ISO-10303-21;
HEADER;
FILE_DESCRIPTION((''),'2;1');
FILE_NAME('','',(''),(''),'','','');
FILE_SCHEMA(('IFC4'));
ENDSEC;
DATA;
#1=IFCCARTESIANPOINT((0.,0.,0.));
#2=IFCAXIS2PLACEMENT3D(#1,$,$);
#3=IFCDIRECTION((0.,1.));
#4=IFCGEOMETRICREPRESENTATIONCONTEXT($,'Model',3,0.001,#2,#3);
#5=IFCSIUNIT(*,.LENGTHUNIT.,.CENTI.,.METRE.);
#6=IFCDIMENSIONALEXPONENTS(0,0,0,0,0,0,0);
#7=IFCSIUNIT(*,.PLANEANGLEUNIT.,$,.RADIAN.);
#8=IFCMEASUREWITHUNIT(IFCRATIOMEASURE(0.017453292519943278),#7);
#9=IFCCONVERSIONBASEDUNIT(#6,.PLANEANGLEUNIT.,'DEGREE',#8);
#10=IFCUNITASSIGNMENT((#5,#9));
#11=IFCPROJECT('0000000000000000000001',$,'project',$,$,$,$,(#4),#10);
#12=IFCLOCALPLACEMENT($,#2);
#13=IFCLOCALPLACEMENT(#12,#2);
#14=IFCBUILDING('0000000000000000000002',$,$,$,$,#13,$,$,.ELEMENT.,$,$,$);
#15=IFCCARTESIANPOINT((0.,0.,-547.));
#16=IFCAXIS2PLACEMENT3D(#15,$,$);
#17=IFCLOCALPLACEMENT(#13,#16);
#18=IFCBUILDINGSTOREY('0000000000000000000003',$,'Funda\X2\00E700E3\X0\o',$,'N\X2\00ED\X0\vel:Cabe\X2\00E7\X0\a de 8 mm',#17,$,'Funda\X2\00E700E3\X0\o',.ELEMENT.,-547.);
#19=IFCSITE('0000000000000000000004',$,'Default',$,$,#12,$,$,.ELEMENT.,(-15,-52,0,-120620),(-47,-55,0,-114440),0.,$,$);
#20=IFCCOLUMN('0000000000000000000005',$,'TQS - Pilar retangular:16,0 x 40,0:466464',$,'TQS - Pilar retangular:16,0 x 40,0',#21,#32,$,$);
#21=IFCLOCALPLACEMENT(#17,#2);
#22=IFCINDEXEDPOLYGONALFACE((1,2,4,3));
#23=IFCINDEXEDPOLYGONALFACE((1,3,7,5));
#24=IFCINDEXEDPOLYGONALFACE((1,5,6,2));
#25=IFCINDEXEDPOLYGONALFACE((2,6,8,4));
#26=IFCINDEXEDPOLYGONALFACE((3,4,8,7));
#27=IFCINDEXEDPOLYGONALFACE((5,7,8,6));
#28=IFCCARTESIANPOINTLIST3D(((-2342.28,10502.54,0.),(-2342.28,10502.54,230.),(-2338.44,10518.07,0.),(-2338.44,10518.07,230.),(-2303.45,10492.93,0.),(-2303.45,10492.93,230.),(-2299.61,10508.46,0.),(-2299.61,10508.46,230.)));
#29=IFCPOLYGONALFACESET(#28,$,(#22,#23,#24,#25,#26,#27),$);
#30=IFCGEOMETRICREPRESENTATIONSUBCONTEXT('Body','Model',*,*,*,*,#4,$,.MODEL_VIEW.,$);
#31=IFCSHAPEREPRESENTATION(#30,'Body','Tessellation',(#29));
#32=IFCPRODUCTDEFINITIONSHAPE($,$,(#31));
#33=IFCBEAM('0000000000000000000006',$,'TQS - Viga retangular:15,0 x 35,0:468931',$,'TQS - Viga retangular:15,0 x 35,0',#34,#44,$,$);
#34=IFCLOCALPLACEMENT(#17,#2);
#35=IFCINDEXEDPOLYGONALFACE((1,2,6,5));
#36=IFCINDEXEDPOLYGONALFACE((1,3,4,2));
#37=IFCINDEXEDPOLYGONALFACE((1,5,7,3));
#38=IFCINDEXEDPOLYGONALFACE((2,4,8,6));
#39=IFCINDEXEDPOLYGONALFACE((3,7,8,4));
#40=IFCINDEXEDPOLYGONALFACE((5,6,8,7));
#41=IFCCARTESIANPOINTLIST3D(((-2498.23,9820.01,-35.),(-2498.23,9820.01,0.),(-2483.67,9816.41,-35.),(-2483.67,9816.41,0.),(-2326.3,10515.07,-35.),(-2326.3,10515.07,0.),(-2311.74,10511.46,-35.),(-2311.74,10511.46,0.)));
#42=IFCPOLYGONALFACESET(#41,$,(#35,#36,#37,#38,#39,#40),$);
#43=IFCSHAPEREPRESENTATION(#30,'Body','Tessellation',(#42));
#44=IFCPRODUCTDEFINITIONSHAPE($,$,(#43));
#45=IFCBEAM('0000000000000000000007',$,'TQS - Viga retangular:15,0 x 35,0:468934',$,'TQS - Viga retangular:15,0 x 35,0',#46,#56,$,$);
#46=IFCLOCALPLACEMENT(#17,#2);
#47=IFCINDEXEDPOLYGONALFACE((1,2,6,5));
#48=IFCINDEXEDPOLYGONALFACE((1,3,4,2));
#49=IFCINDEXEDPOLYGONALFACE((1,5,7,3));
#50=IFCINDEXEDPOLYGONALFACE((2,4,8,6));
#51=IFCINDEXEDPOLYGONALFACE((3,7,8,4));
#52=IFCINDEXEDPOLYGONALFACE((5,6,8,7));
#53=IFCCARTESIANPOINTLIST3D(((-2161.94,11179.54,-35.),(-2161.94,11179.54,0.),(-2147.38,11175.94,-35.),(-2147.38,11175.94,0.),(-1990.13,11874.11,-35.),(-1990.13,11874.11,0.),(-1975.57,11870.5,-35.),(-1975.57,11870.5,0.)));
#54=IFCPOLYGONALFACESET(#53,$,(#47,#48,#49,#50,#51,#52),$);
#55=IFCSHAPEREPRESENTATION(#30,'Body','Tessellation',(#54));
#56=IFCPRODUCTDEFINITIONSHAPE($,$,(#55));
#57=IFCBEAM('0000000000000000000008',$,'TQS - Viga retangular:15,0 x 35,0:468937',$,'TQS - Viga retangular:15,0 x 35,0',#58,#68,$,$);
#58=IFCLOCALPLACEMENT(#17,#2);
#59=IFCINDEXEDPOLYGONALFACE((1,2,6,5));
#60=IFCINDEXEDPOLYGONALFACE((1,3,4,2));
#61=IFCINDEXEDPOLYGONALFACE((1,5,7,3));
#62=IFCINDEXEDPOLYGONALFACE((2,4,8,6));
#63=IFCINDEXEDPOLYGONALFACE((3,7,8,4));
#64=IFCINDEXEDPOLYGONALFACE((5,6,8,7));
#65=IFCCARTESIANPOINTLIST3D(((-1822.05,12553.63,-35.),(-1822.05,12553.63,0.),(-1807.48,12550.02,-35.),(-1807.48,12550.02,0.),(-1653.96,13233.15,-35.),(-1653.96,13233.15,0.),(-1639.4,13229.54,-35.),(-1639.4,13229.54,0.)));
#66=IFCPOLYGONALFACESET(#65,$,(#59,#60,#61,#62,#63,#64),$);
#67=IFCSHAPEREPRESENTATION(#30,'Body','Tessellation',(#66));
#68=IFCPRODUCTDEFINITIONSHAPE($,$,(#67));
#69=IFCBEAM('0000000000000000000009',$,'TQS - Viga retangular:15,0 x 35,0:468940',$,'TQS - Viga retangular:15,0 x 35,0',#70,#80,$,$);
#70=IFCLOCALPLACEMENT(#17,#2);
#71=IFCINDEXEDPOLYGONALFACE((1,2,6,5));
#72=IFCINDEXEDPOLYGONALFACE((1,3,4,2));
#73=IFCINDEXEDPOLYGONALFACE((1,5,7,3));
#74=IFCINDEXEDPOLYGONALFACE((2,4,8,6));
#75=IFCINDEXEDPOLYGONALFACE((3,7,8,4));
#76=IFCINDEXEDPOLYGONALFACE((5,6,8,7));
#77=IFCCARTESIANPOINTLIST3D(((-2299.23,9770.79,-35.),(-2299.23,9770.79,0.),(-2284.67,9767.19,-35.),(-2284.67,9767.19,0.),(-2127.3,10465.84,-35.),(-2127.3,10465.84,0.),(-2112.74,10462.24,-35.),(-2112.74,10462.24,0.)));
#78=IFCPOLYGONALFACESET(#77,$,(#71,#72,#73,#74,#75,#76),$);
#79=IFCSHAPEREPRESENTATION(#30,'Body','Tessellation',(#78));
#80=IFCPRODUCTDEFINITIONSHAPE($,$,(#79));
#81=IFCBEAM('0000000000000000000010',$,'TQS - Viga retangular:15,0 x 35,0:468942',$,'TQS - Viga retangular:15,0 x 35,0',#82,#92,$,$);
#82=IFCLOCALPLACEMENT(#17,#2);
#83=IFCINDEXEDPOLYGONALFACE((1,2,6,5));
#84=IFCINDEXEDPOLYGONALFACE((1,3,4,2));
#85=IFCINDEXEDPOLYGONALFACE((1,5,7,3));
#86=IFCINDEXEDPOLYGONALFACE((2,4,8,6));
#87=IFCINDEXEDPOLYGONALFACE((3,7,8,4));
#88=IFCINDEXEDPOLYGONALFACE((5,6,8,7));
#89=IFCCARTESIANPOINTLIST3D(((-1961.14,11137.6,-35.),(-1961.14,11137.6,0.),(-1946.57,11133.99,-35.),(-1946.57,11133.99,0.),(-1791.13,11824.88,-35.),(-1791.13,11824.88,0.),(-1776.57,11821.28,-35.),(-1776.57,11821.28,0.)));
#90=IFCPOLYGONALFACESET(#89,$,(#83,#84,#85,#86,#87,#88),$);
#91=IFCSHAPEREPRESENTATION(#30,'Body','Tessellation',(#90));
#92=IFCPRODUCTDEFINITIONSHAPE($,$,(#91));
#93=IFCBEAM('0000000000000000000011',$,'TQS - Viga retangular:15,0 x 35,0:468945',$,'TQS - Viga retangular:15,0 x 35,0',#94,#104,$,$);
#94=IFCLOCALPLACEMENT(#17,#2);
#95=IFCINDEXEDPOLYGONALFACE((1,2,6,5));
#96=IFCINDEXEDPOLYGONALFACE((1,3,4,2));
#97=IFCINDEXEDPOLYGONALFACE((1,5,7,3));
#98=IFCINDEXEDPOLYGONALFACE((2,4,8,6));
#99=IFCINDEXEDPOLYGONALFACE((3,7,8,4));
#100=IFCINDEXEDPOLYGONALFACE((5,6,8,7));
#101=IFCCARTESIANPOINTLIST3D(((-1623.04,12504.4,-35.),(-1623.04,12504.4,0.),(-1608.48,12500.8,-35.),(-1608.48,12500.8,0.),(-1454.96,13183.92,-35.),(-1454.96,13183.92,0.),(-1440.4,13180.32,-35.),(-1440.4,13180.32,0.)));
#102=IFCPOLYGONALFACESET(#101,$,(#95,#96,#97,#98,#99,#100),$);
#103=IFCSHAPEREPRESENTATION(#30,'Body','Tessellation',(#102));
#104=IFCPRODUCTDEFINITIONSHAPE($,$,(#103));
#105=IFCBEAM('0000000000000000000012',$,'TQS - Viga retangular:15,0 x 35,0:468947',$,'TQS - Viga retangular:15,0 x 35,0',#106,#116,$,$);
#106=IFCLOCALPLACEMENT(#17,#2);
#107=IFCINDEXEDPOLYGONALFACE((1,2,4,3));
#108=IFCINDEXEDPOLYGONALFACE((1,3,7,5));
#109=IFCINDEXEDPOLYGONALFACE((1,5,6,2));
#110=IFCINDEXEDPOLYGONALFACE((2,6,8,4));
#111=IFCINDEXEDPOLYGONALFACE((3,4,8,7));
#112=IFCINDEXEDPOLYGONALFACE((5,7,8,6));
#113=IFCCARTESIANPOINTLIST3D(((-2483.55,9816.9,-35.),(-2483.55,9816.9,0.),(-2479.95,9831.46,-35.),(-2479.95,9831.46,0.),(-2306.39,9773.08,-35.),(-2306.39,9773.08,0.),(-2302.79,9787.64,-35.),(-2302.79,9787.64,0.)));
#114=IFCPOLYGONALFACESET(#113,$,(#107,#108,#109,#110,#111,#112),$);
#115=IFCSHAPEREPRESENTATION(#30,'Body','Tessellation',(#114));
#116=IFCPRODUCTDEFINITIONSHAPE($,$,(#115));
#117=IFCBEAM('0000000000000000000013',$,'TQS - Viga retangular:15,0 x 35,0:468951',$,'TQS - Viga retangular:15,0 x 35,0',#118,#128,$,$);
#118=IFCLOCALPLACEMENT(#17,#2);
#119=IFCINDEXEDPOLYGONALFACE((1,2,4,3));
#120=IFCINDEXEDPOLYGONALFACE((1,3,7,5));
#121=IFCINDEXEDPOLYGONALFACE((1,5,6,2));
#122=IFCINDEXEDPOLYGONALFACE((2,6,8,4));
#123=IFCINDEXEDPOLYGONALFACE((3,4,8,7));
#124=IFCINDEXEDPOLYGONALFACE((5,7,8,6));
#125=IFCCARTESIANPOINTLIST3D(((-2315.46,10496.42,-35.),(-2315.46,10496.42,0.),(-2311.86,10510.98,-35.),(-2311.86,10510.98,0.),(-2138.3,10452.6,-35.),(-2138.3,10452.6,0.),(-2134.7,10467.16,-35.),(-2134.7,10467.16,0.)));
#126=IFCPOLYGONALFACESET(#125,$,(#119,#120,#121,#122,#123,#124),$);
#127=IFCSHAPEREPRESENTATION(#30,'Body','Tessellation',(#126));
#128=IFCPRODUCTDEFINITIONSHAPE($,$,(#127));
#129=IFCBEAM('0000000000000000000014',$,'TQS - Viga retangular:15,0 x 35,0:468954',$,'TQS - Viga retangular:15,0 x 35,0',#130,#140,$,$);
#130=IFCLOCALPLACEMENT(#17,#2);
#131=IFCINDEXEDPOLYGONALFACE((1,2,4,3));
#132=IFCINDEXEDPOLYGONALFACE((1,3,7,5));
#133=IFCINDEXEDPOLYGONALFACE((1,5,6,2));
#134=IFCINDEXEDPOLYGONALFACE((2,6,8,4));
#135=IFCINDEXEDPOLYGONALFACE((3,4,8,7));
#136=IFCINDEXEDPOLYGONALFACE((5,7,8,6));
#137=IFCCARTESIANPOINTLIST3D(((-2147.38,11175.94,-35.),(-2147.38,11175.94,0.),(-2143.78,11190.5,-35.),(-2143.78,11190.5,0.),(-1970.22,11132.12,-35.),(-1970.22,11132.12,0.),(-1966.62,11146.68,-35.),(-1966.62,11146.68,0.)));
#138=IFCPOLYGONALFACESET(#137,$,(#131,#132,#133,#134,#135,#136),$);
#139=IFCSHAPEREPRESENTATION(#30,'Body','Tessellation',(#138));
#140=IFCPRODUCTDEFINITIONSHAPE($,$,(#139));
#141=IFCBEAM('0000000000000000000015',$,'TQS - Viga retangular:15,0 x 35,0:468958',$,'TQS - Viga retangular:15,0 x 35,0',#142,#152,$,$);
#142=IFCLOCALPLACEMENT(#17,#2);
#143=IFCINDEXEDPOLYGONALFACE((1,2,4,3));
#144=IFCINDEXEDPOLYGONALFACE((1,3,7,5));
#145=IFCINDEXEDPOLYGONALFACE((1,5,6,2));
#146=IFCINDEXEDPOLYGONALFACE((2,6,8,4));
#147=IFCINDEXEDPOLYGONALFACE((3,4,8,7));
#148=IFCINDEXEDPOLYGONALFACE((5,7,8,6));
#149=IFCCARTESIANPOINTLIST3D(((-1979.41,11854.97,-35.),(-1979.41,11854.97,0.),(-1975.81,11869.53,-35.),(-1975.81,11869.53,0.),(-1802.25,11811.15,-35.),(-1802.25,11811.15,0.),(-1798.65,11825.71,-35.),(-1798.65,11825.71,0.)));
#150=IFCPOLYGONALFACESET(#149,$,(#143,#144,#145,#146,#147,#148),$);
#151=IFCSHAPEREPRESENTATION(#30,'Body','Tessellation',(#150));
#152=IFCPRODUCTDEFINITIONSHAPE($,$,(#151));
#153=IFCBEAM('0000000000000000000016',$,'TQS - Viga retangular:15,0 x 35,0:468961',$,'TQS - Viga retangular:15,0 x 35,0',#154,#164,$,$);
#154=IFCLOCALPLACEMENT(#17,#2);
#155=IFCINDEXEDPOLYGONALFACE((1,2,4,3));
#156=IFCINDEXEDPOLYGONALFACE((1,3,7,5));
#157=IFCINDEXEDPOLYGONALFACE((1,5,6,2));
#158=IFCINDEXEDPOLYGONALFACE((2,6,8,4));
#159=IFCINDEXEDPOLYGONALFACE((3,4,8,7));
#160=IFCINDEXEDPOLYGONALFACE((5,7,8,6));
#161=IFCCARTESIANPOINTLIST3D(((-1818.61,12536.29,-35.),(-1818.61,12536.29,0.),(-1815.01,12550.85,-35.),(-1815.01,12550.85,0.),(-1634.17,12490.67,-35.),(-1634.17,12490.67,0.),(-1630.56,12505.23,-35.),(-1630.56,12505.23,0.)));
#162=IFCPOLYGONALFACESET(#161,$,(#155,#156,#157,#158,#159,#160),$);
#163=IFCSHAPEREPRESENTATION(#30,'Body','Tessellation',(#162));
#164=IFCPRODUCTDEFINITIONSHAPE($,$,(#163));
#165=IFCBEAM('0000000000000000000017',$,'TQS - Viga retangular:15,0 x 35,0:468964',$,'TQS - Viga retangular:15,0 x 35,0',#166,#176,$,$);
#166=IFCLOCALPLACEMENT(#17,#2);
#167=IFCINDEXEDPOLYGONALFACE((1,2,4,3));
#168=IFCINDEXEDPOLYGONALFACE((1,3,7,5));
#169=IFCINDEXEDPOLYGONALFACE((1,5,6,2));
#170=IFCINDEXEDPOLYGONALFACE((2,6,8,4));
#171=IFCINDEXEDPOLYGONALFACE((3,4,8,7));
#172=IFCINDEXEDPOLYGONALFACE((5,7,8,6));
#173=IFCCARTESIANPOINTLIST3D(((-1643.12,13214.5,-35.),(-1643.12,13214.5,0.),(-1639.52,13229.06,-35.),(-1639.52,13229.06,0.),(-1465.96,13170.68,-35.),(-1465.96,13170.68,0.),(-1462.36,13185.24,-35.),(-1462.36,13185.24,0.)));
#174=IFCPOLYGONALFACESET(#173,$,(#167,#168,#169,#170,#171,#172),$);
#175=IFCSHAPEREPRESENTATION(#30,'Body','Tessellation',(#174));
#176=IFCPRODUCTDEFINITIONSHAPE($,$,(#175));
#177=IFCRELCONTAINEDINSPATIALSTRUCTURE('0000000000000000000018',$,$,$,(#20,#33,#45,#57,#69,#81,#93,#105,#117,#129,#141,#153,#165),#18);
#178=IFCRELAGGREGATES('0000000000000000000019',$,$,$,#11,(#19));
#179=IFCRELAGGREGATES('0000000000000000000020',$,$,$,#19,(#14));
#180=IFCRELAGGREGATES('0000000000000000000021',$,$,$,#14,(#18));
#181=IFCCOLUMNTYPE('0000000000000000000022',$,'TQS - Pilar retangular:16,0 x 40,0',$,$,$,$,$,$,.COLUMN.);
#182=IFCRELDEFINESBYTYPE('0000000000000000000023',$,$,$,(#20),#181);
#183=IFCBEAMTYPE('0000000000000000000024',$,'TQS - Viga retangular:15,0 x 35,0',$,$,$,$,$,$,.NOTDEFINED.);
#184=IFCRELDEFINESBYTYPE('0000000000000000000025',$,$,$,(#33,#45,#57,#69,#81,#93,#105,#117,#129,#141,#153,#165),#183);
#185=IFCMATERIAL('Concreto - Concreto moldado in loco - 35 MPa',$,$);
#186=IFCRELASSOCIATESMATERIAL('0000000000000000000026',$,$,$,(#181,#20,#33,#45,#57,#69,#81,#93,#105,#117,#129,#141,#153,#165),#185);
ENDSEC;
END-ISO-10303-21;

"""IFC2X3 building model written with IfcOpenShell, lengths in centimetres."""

from ifc_helpers import new_model, entity, si_unit, converted_unit, direction, frame, frame_2d, origin, origin_2d_with_axis, place, context, subcontext, project, spatial, rectangle, extrude, source, transform, mapped, material, type_object, type_shapes, element, save


model = new_model("IFC2X3")

# Units and contexts
model_context = context("Model", 3, precision=0.001, world=origin(), true_north=direction((0.0, 1.0)))
body_context = subcontext(model_context, "Body", "Model", "MODEL_VIEW")
ifc_project = project(units=[si_unit("LENGTHUNIT", "METRE", prefix="CENTI"), converted_unit("PLANEANGLEUNIT", "DEGREE", entity("IfcRatioMeasure", 0.017453292519943278), si_unit("PLANEANGLEUNIT", "RADIAN"), dimensions=[0, 0, 0, 0, 0, 0, 0])], contexts=[model_context])

# Site, building, storey
site_placement = place(None, origin())
site = spatial("IfcSite", under=ifc_project, at=site_placement, Name="Default", CompositionType="ELEMENT", RefLatitude=(-15, -52, 0, -120620), RefLongitude=(-47, -55, 0, -114440), RefElevation=0.0)
building_placement = place(site_placement, origin())
building = spatial("IfcBuilding", under=site, at=building_placement, CompositionType="ELEMENT")
storey_placement = place(building_placement, frame((0.0, 0.0, -547.0)))
storey = spatial("IfcBuildingStorey", under=building, at=storey_placement, Name="Fundação", ObjectType="Nível:Cabeça de 8 mm", LongName="Fundação", CompositionType="ELEMENT", Elevation=-547.0)

# Column
ifc_material_1 = material(Name="Concreto - Concreto moldado in loco - 35 MPa")
column_type_1 = type_object("IfcColumnType", Name="TQS - Pilar retangular:16,0 x 40,0", PredefinedType="COLUMN", material=ifc_material_1)
shared_shape_1 = source(origin(), body_context, "Body", "SweptSolid", [
    extrude(rectangle(XDim=40.0, YDim=16.0, at=origin_2d_with_axis()), frame((-2320.94, 10505.5, -547.0), z_axis=(0.0, 0.0, 1.0), x_axis=(-0.970743, 0.240122, 0.0)), (0.0, 0.0, 1.0), 230.0),
])
type_shapes(column_type_1, [shared_shape_1])
column_1_placement = place(storey_placement, frame((0.0, 0.0, 547.0)))
element("IfcColumn", 1, at=column_1_placement, inside=storey, type_object=column_type_1, material=ifc_material_1, Name="TQS - Pilar retangular:16,0 x 40,0:466464", ObjectType="TQS - Pilar retangular:16,0 x 40,0", context=body_context, shape_type="MappedRepresentation", body=[
    mapped(shared_shape_1, transform((0.0, 0.0, 0.0), scale=1.0)),
])

# Beams
beam_type = type_object("IfcBeamType", Name="TQS - Viga retangular:15,0 x 35,0", PredefinedType="NOTDEFINED")
beam_1_placement = place(storey_placement, frame((-2490.95, 9818.21, 0.0), z_axis=(0.0, 0.0, 1.0), x_axis=(0.240122, 0.970743, 0.0)))
element("IfcBeam", 2, at=beam_1_placement, inside=storey, type_object=beam_type, material=ifc_material_1, Name="TQS - Viga retangular:15,0 x 35,0:468931", ObjectType="TQS - Viga retangular:15,0 x 35,0", context=body_context, shape_type="SweptSolid", body=[
    extrude(rectangle(XDim=35.0, YDim=15.0, at=frame_2d((0.0, 0.0), x_axis=(1.0, 0.0))), frame((0.0, 0.0, -17.5), z_axis=(1.0, 0.0, 0.0), x_axis=(0.0, 0.0, -1.0)), (0.0, 0.0, 1.0), 716.0),
])
beam_2_placement = place(storey_placement, frame((-2152.86, 11185.02, 0.0), z_axis=(0.0, 0.0, 1.0), x_axis=(0.240122, 0.970743, 0.0)))
element("IfcBeam", 3, at=beam_2_placement, inside=storey, type_object=beam_type, material=ifc_material_1, Name="TQS - Viga retangular:15,0 x 35,0:468934", ObjectType="TQS - Viga retangular:15,0 x 35,0", context=body_context, shape_type="SweptSolid", body=[
    extrude(rectangle(XDim=35.0, YDim=15.0, at=frame_2d((0.0, 0.0), x_axis=(1.0, 0.0))), frame((-7.5, 0.0, -17.5), z_axis=(1.0, 0.0, 0.0), x_axis=(0.0, 0.0, -1.0)), (0.0, 0.0, 1.0), 715.5),
])
beam_3_placement = place(storey_placement, frame((-1814.77, 12551.83, 0.0), z_axis=(0.0, 0.0, 1.0), x_axis=(0.240122, 0.970743, 0.0)))
element("IfcBeam", 4, at=beam_3_placement, inside=storey, type_object=beam_type, material=ifc_material_1, Name="TQS - Viga retangular:15,0 x 35,0:468937", ObjectType="TQS - Viga retangular:15,0 x 35,0", context=body_context, shape_type="SweptSolid", body=[
    extrude(rectangle(XDim=35.0, YDim=15.0, at=frame_2d((0.0, 0.0), x_axis=(1.0, 0.0))), frame((0.0, 0.0, -17.5), z_axis=(1.0, 0.0, 0.0), x_axis=(0.0, 0.0, -1.0)), (0.0, 0.0, 1.0), 700.0),
])
beam_4_placement = place(storey_placement, frame((-2291.95, 9768.99, 0.0), z_axis=(0.0, 0.0, 1.0), x_axis=(0.240122, 0.970743, 0.0)))
element("IfcBeam", 5, at=beam_4_placement, inside=storey, type_object=beam_type, material=ifc_material_1, Name="TQS - Viga retangular:15,0 x 35,0:468940", ObjectType="TQS - Viga retangular:15,0 x 35,0", context=body_context, shape_type="SweptSolid", body=[
    extrude(rectangle(XDim=35.0, YDim=15.0, at=frame_2d((0.0, 0.0), x_axis=(1.0, 0.0))), frame((0.0, 0.0, -17.5), z_axis=(1.0, 0.0, 0.0), x_axis=(0.0, 0.0, -1.0)), (0.0, 0.0, 1.0), 716.0),
])
beam_5_placement = place(storey_placement, frame((-1953.86, 11135.79, 0.0), z_axis=(0.0, 0.0, 1.0), x_axis=(0.240122, 0.970743, 0.0)))
element("IfcBeam", 6, at=beam_5_placement, inside=storey, type_object=beam_type, material=ifc_material_1, Name="TQS - Viga retangular:15,0 x 35,0:468942", ObjectType="TQS - Viga retangular:15,0 x 35,0", context=body_context, shape_type="SweptSolid", body=[
    extrude(rectangle(XDim=35.0, YDim=15.0, at=frame_2d((0.0, 0.0), x_axis=(1.0, 0.0))), frame((0.0, 0.0, -17.5), z_axis=(1.0, 0.0, 0.0), x_axis=(0.0, 0.0, -1.0)), (0.0, 0.0, 1.0), 708.0),
])
beam_6_placement = place(storey_placement, frame((-1615.76, 12502.6, 0.0), z_axis=(0.0, 0.0, 1.0), x_axis=(0.240122, 0.970743, 0.0)))
element("IfcBeam", 7, at=beam_6_placement, inside=storey, type_object=beam_type, material=ifc_material_1, Name="TQS - Viga retangular:15,0 x 35,0:468945", ObjectType="TQS - Viga retangular:15,0 x 35,0", context=body_context, shape_type="SweptSolid", body=[
    extrude(rectangle(XDim=35.0, YDim=15.0, at=frame_2d((0.0, 0.0), x_axis=(1.0, 0.0))), frame((0.0, 0.0, -17.5), z_axis=(1.0, 0.0, 0.0), x_axis=(0.0, 0.0, -1.0)), (0.0, 0.0, 1.0), 700.0),
])
beam_7_placement = place(storey_placement, frame((-2304.59, 9780.36, 0.0), z_axis=(0.0, 0.0, 1.0), x_axis=(-0.970743, 0.240122, 0.0)))
element("IfcBeam", 8, at=beam_7_placement, inside=storey, type_object=beam_type, material=ifc_material_1, Name="TQS - Viga retangular:15,0 x 35,0:468947", ObjectType="TQS - Viga retangular:15,0 x 35,0", context=body_context, shape_type="SweptSolid", body=[
    extrude(rectangle(XDim=35.0, YDim=15.0, at=frame_2d((0.0, 0.0), x_axis=(1.0, 0.0))), frame((0.0, 0.0, -17.5), z_axis=(1.0, 0.0, 0.0), x_axis=(0.0, 0.0, -1.0)), (0.0, 0.0, 1.0), 182.5),
])
beam_8_placement = place(storey_placement, frame((-2136.5, 10459.88, 0.0), z_axis=(0.0, 0.0, 1.0), x_axis=(-0.970743, 0.240122, 0.0)))
element("IfcBeam", 9, at=beam_8_placement, inside=storey, type_object=beam_type, material=ifc_material_1, Name="TQS - Viga retangular:15,0 x 35,0:468951", ObjectType="TQS - Viga retangular:15,0 x 35,0", context=body_context, shape_type="SweptSolid", body=[
    extrude(rectangle(XDim=35.0, YDim=15.0, at=frame_2d((0.0, 0.0), x_axis=(1.0, 0.0))), frame((0.0, 0.0, -17.5), z_axis=(1.0, 0.0, 0.0), x_axis=(0.0, 0.0, -1.0)), (0.0, 0.0, 1.0), 182.5),
])
beam_9_placement = place(storey_placement, frame((-1968.42, 11139.4, 0.0), z_axis=(0.0, 0.0, 1.0), x_axis=(-0.970743, 0.240122, 0.0)))
element("IfcBeam", 10, at=beam_9_placement, inside=storey, type_object=beam_type, material=ifc_material_1, Name="TQS - Viga retangular:15,0 x 35,0:468954", ObjectType="TQS - Viga retangular:15,0 x 35,0", context=body_context, shape_type="SweptSolid", body=[
    extrude(rectangle(XDim=35.0, YDim=15.0, at=frame_2d((0.0, 0.0), x_axis=(1.0, 0.0))), frame((0.0, 0.0, -17.5), z_axis=(1.0, 0.0, 0.0), x_axis=(0.0, 0.0, -1.0)), (0.0, 0.0, 1.0), 182.5),
])
beam_10_placement = place(storey_placement, frame((-1800.45, 11818.43, 0.0), z_axis=(0.0, 0.0, 1.0), x_axis=(-0.970743, 0.240122, 0.0)))
element("IfcBeam", 11, at=beam_10_placement, inside=storey, type_object=beam_type, material=ifc_material_1, Name="TQS - Viga retangular:15,0 x 35,0:468958", ObjectType="TQS - Viga retangular:15,0 x 35,0", context=body_context, shape_type="SweptSolid", body=[
    extrude(rectangle(XDim=35.0, YDim=15.0, at=frame_2d((0.0, 0.0), x_axis=(1.0, 0.0))), frame((0.0, 0.0, -17.5), z_axis=(1.0, 0.0, 0.0), x_axis=(0.0, 0.0, -1.0)), (0.0, 0.0, 1.0), 182.5),
])
beam_11_placement = place(storey_placement, frame((-1632.37, 12497.95, 0.0), z_axis=(0.0, 0.0, 1.0), x_axis=(-0.970743, 0.240122, 0.0)))
element("IfcBeam", 12, at=beam_11_placement, inside=storey, type_object=beam_type, material=ifc_material_1, Name="TQS - Viga retangular:15,0 x 35,0:468961", ObjectType="TQS - Viga retangular:15,0 x 35,0", context=body_context, shape_type="SweptSolid", body=[
    extrude(rectangle(XDim=35.0, YDim=15.0, at=frame_2d((0.0, 0.0), x_axis=(1.0, 0.0))), frame((0.0, 0.0, -17.5), z_axis=(1.0, 0.0, 0.0), x_axis=(0.0, 0.0, -1.0)), (0.0, 0.0, 1.0), 190.0),
])
beam_12_placement = place(storey_placement, frame((-1464.16, 13177.96, 0.0), z_axis=(0.0, 0.0, 1.0), x_axis=(-0.970743, 0.240122, 0.0)))
element("IfcBeam", 13, at=beam_12_placement, inside=storey, type_object=beam_type, material=ifc_material_1, Name="TQS - Viga retangular:15,0 x 35,0:468964", ObjectType="TQS - Viga retangular:15,0 x 35,0", context=body_context, shape_type="SweptSolid", body=[
    extrude(rectangle(XDim=35.0, YDim=15.0, at=frame_2d((0.0, 0.0), x_axis=(1.0, 0.0))), frame((0.0, 0.0, -17.5), z_axis=(1.0, 0.0, 0.0), x_axis=(0.0, 0.0, -1.0)), (0.0, 0.0, 1.0), 182.5),
])

save(model, "model.ifc")
